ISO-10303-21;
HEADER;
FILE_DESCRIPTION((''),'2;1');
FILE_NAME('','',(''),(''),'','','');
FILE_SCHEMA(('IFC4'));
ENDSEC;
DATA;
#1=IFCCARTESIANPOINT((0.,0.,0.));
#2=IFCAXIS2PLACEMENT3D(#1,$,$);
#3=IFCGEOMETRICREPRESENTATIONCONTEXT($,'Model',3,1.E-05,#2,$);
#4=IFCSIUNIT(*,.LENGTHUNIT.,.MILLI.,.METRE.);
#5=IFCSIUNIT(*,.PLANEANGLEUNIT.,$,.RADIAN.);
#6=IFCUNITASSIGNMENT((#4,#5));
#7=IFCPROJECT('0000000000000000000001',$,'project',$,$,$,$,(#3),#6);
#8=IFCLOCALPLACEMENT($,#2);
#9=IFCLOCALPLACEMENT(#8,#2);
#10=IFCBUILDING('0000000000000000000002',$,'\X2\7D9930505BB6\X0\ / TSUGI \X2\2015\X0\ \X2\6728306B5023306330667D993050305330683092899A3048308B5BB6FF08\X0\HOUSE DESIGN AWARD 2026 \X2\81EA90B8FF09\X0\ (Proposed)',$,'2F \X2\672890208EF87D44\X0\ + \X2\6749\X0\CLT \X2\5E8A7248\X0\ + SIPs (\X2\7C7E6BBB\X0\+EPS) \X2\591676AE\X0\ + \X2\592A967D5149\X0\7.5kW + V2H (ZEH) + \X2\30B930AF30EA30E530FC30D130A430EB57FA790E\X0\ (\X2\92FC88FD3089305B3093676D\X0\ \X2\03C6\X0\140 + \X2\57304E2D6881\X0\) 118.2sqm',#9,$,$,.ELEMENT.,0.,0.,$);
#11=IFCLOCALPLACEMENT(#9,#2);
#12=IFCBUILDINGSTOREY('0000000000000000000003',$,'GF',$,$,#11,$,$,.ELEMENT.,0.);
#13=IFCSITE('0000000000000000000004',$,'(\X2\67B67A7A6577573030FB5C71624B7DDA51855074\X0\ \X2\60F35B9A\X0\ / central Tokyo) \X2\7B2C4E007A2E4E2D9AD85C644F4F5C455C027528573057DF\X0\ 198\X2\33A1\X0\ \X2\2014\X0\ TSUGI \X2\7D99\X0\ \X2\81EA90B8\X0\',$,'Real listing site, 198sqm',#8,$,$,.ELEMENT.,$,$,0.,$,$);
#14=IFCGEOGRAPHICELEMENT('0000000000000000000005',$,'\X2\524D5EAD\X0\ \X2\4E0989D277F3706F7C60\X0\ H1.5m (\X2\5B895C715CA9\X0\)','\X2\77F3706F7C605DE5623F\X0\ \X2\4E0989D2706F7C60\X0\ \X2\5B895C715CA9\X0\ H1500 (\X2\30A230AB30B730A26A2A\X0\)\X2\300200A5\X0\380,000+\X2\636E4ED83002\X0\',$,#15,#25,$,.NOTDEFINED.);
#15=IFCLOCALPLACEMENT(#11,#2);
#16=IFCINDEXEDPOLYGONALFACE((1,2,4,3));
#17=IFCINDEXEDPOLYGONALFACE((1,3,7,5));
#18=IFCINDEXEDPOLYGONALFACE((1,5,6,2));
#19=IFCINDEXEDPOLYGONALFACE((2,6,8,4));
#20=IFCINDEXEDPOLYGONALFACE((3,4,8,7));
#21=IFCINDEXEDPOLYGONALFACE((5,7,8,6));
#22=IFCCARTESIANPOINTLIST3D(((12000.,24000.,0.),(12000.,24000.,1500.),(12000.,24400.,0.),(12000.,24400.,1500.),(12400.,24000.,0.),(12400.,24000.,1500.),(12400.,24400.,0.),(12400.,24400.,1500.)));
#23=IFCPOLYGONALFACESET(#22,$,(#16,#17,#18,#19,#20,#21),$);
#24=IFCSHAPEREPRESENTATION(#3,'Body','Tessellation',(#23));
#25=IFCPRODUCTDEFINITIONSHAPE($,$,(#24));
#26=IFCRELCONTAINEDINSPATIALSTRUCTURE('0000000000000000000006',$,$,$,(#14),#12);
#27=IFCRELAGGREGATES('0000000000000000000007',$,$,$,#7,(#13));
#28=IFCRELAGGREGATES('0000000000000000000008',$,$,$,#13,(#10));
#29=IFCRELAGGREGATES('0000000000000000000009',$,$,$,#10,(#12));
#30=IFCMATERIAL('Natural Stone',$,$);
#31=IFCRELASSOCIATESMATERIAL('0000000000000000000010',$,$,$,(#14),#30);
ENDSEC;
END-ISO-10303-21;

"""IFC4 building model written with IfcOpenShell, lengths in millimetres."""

from ifc_helpers import new_model, si_unit, frame, frame_2d, origin, place, context, project, spatial, rectangle, extrude, material, element, save


model = new_model("IFC4")

# Units and contexts
model_context = context("Model", 3, precision=1e-05, world=origin())
ifc_project = project(units=[si_unit("LENGTHUNIT", "METRE", prefix="MILLI"), si_unit("PLANEANGLEUNIT", "RADIAN")], contexts=[model_context])

# Site, building, storey
site_placement = place(None, origin())
site = spatial("IfcSite", under=ifc_project, at=site_placement, Name="(架空敷地・山手線内側 想定 / central Tokyo) 第一種中高層住居専用地域 198㎡ — TSUGI 継 自邸", ObjectType="Real listing site, 198sqm", CompositionType="ELEMENT", RefElevation=0.0)
building_placement = place(site_placement, origin())
building = spatial("IfcBuilding", under=site, at=building_placement, Name="継ぐ家 / TSUGI ― 木に倣って継ぐことを覚える家（HOUSE DESIGN AWARD 2026 自邸） (Proposed)", ObjectType="2F 木造軸組 + 杉CLT 床版 + SIPs (籾殻+EPS) 外皮 + 太陽光7.5kW + V2H (ZEH) + スクリューパイル基礎 (鋼製らせん杭 φ140 + 地中梁) 118.2sqm", CompositionType="ELEMENT", ElevationOfRefHeight=0.0, ElevationOfTerrain=0.0)
storey_placement = place(building_placement, origin())
storey = spatial("IfcBuildingStorey", under=building, at=storey_placement, Name="GF", CompositionType="ELEMENT", Elevation=0.0)

# Geographic element
ifc_material_1 = material(Name="Natural Stone")
geographic_element_1_placement = place(storey_placement, frame((6000.0, 12000.0, 0.0)))
element("IfcGeographicElement", 1, at=geographic_element_1_placement, inside=storey, material=ifc_material_1, Name="前庭 三角石灯籠 H1.5m (安山岩)", Description="石灯籠工房 三角灯籠 安山岩 H1500 (アカシア横)。¥380,000+据付。", PredefinedType="NOTDEFINED", context=model_context, shape_type="SweptSolid", body=[
    extrude(rectangle(XDim=400.0, YDim=400.0, at=frame_2d((200.0, 200.0))), frame((6000.0, 12000.0, 0.0)), (0.0, 0.0, 1.0), 1500.0),
])

save(model, "model.ifc")
